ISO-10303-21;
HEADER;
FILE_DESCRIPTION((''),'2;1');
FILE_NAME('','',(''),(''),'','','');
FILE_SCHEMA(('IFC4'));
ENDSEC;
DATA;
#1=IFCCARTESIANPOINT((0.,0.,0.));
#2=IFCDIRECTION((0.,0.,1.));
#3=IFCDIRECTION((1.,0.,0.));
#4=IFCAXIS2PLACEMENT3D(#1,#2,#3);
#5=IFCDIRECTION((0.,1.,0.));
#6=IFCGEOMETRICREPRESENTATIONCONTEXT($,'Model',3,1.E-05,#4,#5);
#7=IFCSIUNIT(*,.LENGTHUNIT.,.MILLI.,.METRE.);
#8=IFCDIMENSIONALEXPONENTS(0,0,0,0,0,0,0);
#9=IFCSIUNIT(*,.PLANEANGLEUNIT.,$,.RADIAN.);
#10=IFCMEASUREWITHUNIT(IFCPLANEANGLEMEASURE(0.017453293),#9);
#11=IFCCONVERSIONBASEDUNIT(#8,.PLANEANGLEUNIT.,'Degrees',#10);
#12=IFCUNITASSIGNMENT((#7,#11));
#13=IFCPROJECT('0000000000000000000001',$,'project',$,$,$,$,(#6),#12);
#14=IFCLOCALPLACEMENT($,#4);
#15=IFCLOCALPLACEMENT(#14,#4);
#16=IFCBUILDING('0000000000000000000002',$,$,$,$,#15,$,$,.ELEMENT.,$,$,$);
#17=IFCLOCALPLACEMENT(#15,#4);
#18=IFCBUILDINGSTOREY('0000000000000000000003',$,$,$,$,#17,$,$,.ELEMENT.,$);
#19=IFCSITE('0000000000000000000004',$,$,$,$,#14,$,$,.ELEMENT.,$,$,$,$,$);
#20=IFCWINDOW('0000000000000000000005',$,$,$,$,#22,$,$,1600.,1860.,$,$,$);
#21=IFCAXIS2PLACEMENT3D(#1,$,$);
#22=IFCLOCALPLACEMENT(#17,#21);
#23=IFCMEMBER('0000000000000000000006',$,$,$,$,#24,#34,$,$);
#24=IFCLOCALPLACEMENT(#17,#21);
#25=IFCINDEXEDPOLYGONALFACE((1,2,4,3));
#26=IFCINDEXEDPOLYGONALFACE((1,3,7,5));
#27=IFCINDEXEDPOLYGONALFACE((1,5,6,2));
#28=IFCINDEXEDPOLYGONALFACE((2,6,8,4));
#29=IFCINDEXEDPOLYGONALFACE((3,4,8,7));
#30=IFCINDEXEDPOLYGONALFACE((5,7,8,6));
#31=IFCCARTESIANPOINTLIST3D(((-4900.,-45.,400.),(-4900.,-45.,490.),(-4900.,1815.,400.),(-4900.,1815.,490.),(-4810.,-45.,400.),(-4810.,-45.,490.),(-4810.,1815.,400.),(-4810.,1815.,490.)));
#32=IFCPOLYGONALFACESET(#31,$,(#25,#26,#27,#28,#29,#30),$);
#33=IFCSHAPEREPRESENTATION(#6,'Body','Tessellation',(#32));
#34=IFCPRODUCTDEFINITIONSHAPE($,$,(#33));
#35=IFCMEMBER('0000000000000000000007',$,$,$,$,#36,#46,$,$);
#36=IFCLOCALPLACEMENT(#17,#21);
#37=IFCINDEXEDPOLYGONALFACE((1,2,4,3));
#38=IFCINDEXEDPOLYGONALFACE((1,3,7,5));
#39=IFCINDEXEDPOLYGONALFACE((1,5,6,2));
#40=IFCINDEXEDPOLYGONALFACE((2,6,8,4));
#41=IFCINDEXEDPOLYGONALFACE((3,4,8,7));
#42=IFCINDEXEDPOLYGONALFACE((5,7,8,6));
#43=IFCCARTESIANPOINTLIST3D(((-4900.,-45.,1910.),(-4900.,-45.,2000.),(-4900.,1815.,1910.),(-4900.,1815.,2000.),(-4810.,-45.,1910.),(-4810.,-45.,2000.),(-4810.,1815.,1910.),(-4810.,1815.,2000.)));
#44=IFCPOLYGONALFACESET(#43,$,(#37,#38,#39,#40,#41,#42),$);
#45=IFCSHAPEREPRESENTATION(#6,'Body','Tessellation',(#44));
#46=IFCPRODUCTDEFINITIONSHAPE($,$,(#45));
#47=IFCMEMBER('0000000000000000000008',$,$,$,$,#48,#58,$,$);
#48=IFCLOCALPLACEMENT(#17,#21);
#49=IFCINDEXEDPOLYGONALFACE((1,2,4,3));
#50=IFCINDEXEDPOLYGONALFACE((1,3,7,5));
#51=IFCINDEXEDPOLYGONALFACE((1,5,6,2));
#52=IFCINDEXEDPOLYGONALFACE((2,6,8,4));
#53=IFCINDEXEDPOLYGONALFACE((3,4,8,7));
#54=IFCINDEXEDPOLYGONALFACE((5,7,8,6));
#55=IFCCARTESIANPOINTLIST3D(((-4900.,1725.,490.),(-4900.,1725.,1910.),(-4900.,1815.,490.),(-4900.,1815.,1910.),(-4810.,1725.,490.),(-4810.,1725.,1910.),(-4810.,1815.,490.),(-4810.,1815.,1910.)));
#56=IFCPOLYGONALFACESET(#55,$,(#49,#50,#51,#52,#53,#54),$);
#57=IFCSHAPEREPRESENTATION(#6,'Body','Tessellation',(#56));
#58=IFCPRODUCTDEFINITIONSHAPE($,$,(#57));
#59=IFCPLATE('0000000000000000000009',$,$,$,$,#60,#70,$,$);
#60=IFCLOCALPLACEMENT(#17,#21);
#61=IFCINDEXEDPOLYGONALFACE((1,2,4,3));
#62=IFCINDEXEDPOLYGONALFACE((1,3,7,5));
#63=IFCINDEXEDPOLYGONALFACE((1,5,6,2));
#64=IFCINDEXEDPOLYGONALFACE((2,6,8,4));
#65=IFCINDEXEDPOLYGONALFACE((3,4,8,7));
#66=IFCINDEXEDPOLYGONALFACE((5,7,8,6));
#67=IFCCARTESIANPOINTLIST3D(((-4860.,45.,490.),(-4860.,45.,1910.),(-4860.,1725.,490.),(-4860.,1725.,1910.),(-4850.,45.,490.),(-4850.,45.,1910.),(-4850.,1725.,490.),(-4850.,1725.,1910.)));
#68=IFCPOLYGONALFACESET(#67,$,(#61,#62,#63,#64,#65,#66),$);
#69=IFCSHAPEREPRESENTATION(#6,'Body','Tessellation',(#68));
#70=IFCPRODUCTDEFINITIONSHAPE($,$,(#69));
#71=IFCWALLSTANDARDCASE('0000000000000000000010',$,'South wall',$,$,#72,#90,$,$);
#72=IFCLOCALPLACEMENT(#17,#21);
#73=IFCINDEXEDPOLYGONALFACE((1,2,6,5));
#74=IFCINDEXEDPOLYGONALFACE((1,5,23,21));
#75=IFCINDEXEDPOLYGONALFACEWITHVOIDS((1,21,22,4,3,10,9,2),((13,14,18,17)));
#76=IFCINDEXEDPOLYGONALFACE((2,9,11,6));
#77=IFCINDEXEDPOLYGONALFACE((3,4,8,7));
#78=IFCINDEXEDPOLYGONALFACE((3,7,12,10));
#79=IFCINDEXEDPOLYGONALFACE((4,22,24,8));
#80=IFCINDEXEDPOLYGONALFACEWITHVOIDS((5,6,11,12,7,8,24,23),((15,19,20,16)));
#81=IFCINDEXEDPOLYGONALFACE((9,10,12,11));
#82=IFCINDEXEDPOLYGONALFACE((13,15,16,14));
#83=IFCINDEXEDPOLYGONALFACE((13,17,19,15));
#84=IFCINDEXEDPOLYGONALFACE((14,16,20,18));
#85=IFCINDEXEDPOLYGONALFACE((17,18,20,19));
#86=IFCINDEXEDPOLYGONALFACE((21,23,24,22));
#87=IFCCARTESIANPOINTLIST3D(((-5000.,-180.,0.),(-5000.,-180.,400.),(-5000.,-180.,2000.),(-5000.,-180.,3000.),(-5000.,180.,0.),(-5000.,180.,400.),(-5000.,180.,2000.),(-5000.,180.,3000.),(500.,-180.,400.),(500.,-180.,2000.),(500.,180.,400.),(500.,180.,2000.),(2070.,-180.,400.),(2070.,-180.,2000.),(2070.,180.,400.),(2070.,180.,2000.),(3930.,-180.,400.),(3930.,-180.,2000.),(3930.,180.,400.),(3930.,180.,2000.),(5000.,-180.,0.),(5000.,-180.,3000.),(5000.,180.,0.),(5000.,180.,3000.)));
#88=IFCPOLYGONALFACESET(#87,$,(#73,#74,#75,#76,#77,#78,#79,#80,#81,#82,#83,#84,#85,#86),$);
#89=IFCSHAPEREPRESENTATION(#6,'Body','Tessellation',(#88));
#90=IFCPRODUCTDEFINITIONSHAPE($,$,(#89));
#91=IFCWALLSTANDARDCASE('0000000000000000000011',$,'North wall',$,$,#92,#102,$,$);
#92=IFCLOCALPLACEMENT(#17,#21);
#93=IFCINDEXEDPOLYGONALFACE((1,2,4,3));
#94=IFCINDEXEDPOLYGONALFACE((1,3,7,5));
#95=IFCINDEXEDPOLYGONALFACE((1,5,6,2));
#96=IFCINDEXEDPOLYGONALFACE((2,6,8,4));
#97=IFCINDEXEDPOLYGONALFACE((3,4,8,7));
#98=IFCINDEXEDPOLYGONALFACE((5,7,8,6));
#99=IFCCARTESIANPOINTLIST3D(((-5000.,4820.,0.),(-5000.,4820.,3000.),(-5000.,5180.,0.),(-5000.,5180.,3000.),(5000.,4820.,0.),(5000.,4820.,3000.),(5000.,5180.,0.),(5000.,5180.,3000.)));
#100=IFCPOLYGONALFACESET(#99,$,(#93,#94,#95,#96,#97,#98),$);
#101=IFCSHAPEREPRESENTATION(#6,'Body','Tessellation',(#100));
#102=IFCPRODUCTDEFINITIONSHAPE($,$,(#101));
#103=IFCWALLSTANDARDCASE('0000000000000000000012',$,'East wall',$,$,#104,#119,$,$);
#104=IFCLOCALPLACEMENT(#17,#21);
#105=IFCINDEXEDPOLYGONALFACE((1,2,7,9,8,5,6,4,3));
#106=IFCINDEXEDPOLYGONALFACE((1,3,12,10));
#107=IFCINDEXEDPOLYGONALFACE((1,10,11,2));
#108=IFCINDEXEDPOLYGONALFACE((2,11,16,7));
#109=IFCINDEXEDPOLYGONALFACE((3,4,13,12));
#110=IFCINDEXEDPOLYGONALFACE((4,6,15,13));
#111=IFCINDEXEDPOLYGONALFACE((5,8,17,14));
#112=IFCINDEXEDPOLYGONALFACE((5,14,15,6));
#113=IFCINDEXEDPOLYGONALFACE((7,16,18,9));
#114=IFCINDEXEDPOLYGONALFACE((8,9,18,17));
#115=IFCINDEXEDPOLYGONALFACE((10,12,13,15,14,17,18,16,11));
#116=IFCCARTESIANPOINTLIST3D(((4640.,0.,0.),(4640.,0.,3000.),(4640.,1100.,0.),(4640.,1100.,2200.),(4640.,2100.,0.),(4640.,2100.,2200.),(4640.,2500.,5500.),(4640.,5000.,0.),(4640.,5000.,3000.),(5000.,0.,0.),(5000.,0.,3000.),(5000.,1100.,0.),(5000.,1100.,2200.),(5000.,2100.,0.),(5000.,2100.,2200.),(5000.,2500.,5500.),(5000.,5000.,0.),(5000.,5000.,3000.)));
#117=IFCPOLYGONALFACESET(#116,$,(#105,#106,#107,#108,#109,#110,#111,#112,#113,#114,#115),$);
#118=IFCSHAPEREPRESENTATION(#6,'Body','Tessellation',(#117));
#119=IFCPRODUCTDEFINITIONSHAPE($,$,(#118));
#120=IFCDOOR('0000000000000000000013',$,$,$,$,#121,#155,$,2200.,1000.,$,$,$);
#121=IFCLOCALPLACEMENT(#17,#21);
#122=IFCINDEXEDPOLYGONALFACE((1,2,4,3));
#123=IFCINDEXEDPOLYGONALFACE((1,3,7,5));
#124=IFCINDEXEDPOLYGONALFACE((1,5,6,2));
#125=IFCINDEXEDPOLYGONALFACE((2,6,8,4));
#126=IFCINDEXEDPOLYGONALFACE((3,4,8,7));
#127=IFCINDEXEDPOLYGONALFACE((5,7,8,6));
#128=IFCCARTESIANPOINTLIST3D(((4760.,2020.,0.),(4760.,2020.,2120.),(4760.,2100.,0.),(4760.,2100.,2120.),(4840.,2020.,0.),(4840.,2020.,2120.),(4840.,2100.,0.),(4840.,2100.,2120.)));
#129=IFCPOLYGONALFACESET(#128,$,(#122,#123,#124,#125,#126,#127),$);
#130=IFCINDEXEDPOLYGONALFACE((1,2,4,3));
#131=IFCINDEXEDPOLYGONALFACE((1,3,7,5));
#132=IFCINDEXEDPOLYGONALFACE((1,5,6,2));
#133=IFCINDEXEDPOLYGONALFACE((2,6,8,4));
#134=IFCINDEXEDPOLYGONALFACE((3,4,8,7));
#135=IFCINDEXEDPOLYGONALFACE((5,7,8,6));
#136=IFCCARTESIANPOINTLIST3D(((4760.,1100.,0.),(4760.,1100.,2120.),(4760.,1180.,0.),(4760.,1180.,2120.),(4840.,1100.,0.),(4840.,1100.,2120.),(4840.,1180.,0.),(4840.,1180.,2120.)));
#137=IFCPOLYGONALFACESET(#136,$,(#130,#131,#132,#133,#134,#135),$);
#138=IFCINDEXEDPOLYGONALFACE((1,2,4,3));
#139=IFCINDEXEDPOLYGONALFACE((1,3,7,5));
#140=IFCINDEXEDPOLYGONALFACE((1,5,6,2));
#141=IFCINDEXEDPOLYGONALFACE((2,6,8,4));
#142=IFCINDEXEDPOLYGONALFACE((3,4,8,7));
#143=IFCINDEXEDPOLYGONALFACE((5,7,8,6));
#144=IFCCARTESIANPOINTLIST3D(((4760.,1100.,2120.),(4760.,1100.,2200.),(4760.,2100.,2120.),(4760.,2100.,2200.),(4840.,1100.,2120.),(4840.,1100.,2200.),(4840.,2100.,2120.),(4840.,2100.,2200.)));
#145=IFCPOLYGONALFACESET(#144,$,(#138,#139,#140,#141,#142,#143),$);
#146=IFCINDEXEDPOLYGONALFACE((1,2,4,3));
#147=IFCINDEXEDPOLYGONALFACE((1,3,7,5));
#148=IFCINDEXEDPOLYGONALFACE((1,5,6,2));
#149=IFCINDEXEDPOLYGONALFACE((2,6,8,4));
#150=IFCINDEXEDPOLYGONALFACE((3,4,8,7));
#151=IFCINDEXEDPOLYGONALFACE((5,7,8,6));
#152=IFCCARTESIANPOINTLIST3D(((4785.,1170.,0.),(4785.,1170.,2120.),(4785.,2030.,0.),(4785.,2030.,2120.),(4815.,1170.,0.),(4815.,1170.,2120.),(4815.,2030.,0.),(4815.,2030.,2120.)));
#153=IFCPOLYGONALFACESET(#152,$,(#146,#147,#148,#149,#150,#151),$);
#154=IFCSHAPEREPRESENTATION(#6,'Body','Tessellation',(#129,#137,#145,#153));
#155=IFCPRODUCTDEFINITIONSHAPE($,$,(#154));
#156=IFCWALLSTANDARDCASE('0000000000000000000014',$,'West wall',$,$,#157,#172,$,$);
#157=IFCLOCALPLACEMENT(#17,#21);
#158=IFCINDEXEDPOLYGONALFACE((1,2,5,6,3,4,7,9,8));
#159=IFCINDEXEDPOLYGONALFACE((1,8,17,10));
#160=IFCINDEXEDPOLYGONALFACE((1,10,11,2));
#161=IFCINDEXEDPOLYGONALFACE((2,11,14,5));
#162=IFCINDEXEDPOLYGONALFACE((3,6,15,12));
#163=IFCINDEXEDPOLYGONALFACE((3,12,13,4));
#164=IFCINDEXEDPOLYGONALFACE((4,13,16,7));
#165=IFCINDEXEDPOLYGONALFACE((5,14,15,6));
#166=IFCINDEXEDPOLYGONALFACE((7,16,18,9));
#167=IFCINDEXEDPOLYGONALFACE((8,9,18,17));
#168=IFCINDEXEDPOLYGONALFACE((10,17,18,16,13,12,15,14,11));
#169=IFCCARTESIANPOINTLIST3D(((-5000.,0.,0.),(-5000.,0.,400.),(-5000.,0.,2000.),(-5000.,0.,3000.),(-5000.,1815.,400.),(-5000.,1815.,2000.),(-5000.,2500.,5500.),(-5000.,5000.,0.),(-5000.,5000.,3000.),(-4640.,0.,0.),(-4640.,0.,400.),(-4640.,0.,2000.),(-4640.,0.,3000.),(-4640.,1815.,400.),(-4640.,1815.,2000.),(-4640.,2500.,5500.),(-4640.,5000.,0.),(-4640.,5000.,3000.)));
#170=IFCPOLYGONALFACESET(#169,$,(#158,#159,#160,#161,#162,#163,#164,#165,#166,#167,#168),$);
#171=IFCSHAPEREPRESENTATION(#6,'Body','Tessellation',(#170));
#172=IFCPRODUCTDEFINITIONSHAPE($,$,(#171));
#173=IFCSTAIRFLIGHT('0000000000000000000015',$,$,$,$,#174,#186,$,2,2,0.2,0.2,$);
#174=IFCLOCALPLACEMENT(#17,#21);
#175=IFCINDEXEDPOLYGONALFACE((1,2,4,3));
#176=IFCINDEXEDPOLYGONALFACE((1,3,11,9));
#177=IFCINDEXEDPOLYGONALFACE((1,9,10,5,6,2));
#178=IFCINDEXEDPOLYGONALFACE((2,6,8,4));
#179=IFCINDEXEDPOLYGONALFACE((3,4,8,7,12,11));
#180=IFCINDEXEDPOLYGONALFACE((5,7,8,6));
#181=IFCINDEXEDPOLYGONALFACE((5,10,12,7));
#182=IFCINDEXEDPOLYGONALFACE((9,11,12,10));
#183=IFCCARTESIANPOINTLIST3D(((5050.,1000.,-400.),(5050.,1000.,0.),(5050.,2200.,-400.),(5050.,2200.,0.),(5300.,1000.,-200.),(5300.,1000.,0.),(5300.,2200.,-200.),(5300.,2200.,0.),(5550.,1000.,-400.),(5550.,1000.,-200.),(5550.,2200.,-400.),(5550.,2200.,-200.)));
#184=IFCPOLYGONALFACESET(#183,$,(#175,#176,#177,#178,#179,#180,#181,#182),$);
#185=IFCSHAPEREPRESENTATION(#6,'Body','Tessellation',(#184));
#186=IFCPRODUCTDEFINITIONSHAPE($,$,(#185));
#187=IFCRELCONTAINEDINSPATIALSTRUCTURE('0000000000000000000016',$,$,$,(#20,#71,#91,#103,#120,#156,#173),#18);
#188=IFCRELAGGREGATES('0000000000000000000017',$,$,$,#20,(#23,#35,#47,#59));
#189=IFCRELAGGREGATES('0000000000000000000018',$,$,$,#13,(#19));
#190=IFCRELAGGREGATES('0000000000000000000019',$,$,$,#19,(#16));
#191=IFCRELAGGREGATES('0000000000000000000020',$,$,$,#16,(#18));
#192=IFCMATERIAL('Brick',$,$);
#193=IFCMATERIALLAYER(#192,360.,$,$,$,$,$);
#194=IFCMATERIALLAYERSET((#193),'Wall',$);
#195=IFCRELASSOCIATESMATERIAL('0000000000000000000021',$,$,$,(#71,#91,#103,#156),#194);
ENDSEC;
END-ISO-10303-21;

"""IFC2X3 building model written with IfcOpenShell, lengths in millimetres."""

from ifc_helpers import new_model, entity, si_unit, converted_unit, direction, frame, origin_with_axes, place, context, project, spatial, polyline, outline, extrude, clip, halfspace, material, layer, layer_set, layer_usage, element, fill, aggregate, save


model = new_model("IFC2X3")

# Units and contexts
model_context = context("Model", 3, precision=1e-05, world=origin_with_axes(), true_north=direction((0.0, 1.0, 0.0)))
ifc_project = project(units=[si_unit("LENGTHUNIT", "METRE", prefix="MILLI"), converted_unit("PLANEANGLEUNIT", "Degrees", entity("IfcPlaneAngleMeasure", 0.017453293), si_unit("PLANEANGLEUNIT", "RADIAN"), dimensions=[0, 0, 0, 0, 0, 0, 0])], contexts=[model_context])

# Site, building, storey
site_placement = place(None, origin_with_axes())
site = spatial("IfcSite", under=ifc_project, at=site_placement, CompositionType="ELEMENT")
building_placement = place(site_placement, origin_with_axes())
building = spatial("IfcBuilding", under=site, at=building_placement, CompositionType="ELEMENT")
storey_placement = place(building_placement, origin_with_axes())
storey = spatial("IfcBuildingStorey", under=building, at=storey_placement, CompositionType="ELEMENT")

# Window, members
window_1_placement = place(storey_placement, frame((-4810.0, -45.0, 400.0), z_axis=(0.0, 0.0, 1.0), x_axis=(0.0, 1.0, 0.0)))
window_1 = element("IfcWindow", 1, at=window_1_placement, inside=storey, OverallHeight=1600.0, OverallWidth=1860.0)
member_1_placement = place(window_1_placement, frame((930.0, 45.0, 0.0), z_axis=(0.0, 0.0, 1.0), x_axis=(1.0, 0.0, 0.0)))
member_1 = element("IfcMember", 2, at=member_1_placement, context=model_context, shape_type="SweptSolid", body=[
    extrude(outline(polyline([(-930.0, -45.0), (930.0, -45.0), (930.0, 45.0), (-930.0, 45.0), (-930.0, -45.0)])), origin_with_axes(), (0.0, 0.0, 1.0), 90.0),
])
member_2_placement = place(window_1_placement, frame((930.0, 45.0, 1510.0), z_axis=(0.0, 0.0, 1.0), x_axis=(1.0, 0.0, 0.0)))
member_2 = element("IfcMember", 3, at=member_2_placement, context=model_context, shape_type="SweptSolid", body=[
    extrude(outline(polyline([(-930.0, -45.0), (930.0, -45.0), (930.0, 45.0), (-930.0, 45.0), (-930.0, -45.0)])), origin_with_axes(), (0.0, 0.0, 1.0), 90.0),
])
member_3_placement = place(window_1_placement, frame((1815.0, 45.0, 90.0), z_axis=(0.0, 0.0, 1.0), x_axis=(1.0, 0.0, 0.0)))
member_3 = element("IfcMember", 4, at=member_3_placement, context=model_context, shape_type="SweptSolid", body=[
    extrude(outline(polyline([(-45.0, -45.0), (45.0, -45.0), (45.0, 45.0), (-45.0, 45.0), (-45.0, -45.0)])), origin_with_axes(), (0.0, 0.0, 1.0), 1420.0),
])

# Plate
plate_1_placement = place(window_1_placement, frame((930.0, 45.0, 90.0), z_axis=(0.0, 0.0, 1.0), x_axis=(1.0, 0.0, 0.0)))
plate_1 = element("IfcPlate", 5, at=plate_1_placement, context=model_context, shape_type="SweptSolid", body=[
    extrude(outline(polyline([(-840.0, -5.0), (840.0, -5.0), (840.0, 5.0), (-840.0, 5.0), (-840.0, -5.0)])), origin_with_axes(), (0.0, 0.0, 1.0), 1420.0),
])
aggregate(window_1, [member_1, member_2, member_3, plate_1])

# Wall, openings
ifc_material = material(Name="Brick")
ifc_layer = layer(ifc_material, 360.0)
ifc_layer_set = layer_set([ifc_layer], Name="Wall")
ifc_layer_usage = layer_usage(ifc_layer_set, "AXIS2", "POSITIVE", -180.0)
wall_1_placement = place(None, origin_with_axes())
wall_1 = element("IfcWallStandardCase", 6, at=wall_1_placement, inside=storey, material=ifc_layer_usage, Name="South wall", context=model_context, shape_type="SweptSolid", body=[
    extrude(outline(polyline([(-5000.0, -180.0), (5000.0, -180.0), (5000.0, 180.0), (-5000.0, 180.0), (-5000.0, -180.0)])), origin_with_axes(), (0.0, 0.0, 1.0), 3000.0),
])
placement = place(None, frame((-2500.0, 0.0, 400.0), z_axis=(0.0, 0.0, 1.0), x_axis=(1.0, 0.0, 0.0)))
element("IfcOpeningElement", 7, at=placement, cuts=wall_1, context=model_context, shape_type="SweptSolid", body=[
    extrude(outline(polyline([(-3000.0, -1815.0), (3000.0, -1815.0), (3000.0, 1815.0), (-3000.0, 1815.0), (-3000.0, -1815.0)])), origin_with_axes(), (0.0, 0.0, 1.0), 1600.0),
])
opening_1_placement = place(None, frame((3000.0, 0.0, 400.0), z_axis=(0.0, 0.0, 1.0), x_axis=(1.0, 0.0, 0.0)))
element("IfcOpeningElement", 8, at=opening_1_placement, cuts=wall_1, context=model_context, shape_type="SweptSolid", body=[
    extrude(outline(polyline([(-930.0, -1500.0), (930.0, -1500.0), (930.0, 1500.0), (-930.0, 1500.0), (-930.0, -1500.0)])), origin_with_axes(), (0.0, 0.0, 1.0), 1600.0),
])

# Wall
wall_2_placement = place(storey_placement, frame((0.0, 5000.0, 0.0), z_axis=(0.0, 0.0, 1.0), x_axis=(1.0, 0.0, 0.0)))
element("IfcWallStandardCase", 9, at=wall_2_placement, inside=storey, material=ifc_layer_usage, Name="North wall", context=model_context, shape_type="SweptSolid", body=[
    extrude(outline(polyline([(-5000.0, -180.0), (5000.0, -180.0), (5000.0, 180.0), (-5000.0, 180.0), (-5000.0, -180.0)])), origin_with_axes(), (0.0, 0.0, 1.0), 3000.0),
])

# Wall, opening, door
wall_3_placement = place(storey_placement, frame((4820.0, 2500.0, 0.0), z_axis=(0.0, 0.0, 1.0), x_axis=(0.0, 1.0, 0.0)))
wall_3 = element("IfcWallStandardCase", 10, at=wall_3_placement, inside=storey, material=ifc_layer_usage, Name="East wall", context=model_context, shape_type="Clipping", body=[
    clip(clip(extrude(outline(polyline([(-2500.0, -180.0), (2500.0, -180.0), (2500.0, 180.0), (-2500.0, 180.0), (-2500.0, -180.0)])), origin_with_axes(), (0.0, 0.0, 1.0), 6000.0), halfspace(frame((-2500.0, 0.0, 3000.0), z_axis=(-1.0, 0.0, 1.0), x_axis=(1.0, 0.0, 0.0)), False)), halfspace(frame((2500.0, 0.0, 3000.0), z_axis=(1.0, 0.0, 1.0), x_axis=(1.0, 0.0, 0.0)), False)),
])
opening_2_placement = place(None, frame((4820.0, 1600.0, 0.0), z_axis=(0.0, 0.0, 1.0), x_axis=(1.0, 0.0, 0.0)))
opening_2 = element("IfcOpeningElement", 11, at=opening_2_placement, cuts=wall_3, context=model_context, shape_type="SweptSolid", body=[
    extrude(outline(polyline([(-500.0, -500.0), (500.0, -500.0), (500.0, 500.0), (-500.0, 500.0), (-500.0, -500.0)])), origin_with_axes(), (0.0, 0.0, 1.0), 2200.0),
])
door_placement = place(storey_placement, frame((4800.0, 1600.0, 0.0), z_axis=(0.0, 0.0, 1.0), x_axis=(0.0, 1.0, 0.0)))
door = element("IfcDoor", 12, at=door_placement, inside=storey, OverallHeight=2200.0, OverallWidth=1000.0, context=model_context, shape_type="SweptSolid", body=[
    extrude(outline(polyline([(-40.0, -40.0), (40.0, -40.0), (40.0, 40.0), (-40.0, 40.0), (-40.0, -40.0)])), frame((460.0, 0.0, 0.0), z_axis=(0.0, 0.0, 1.0), x_axis=(1.0, 0.0, 0.0)), (0.0, 0.0, 1.0), 2120.0),
    extrude(outline(polyline([(-40.0, -40.0), (40.0, -40.0), (40.0, 40.0), (-40.0, 40.0), (-40.0, -40.0)])), frame((-460.0, 0.0, 0.0), z_axis=(0.0, 0.0, 1.0), x_axis=(1.0, 0.0, 0.0)), (0.0, 0.0, 1.0), 2120.0),
    extrude(outline(polyline([(-500.0, -40.0), (500.0, -40.0), (500.0, 40.0), (-500.0, 40.0), (-500.0, -40.0)])), frame((0.0, 0.0, 2120.0), z_axis=(0.0, 0.0, 1.0), x_axis=(1.0, 0.0, 0.0)), (0.0, 0.0, 1.0), 80.0),
    extrude(outline(polyline([(-430.0, -15.0), (430.0, -15.0), (430.0, 15.0), (-430.0, 15.0), (-430.0, -15.0)])), origin_with_axes(), (0.0, 0.0, 1.0), 2120.0),
])
fill(opening_2, door)

# Wall, opening
wall_4_placement = place(storey_placement, frame((-4820.0, 2500.0, 0.0), z_axis=(0.0, 0.0, 1.0), x_axis=(0.0, -1.0, 0.0)))
wall_4 = element("IfcWallStandardCase", 13, at=wall_4_placement, inside=storey, material=ifc_layer_usage, Name="West wall", context=model_context, shape_type="Clipping", body=[
    clip(clip(extrude(outline(polyline([(-2500.0, -180.0), (2500.0, -180.0), (2500.0, 180.0), (-2500.0, 180.0), (-2500.0, -180.0)])), origin_with_axes(), (0.0, 0.0, 1.0), 6000.0), halfspace(frame((-2500.0, 0.0, 3000.0), z_axis=(-1.0, 0.0, 1.0), x_axis=(1.0, 0.0, 0.0)), False)), halfspace(frame((2500.0, 0.0, 3000.0), z_axis=(1.0, 0.0, 1.0), x_axis=(1.0, 0.0, 0.0)), False)),
])
element("IfcOpeningElement", 14, at=placement, cuts=wall_4, context=model_context, shape_type="SweptSolid", body=[
    extrude(outline(polyline([(-3000.0, -1815.0), (3000.0, -1815.0), (3000.0, 1815.0), (-3000.0, 1815.0), (-3000.0, -1815.0)])), origin_with_axes(), (0.0, 0.0, 1.0), 1600.0),
])

# Stair flight
stair_flight_placement = place(storey_placement, frame((5050.0, 1000.0, 0.0), z_axis=(0.0, 1.0, 0.0), x_axis=(1.0, 0.0, 0.0)))
element("IfcStairFlight", 15, at=stair_flight_placement, inside=storey, NumberOfRiser=2, NumberOfTreads=2, RiserHeight=0.2, TreadLength=0.2, context=model_context, shape_type="SweptSolid", body=[
    extrude(outline(polyline([(0.0, 0.0), (250.0, 0.0), (250.0, 200.0), (500.0, 200.0), (500.0, 400.0), (0.0, 400.0), (0.0, 0.0)])), origin_with_axes(), (0.0, 0.0, 1.0), 1200.0),
])

save(model, "model.ifc")
